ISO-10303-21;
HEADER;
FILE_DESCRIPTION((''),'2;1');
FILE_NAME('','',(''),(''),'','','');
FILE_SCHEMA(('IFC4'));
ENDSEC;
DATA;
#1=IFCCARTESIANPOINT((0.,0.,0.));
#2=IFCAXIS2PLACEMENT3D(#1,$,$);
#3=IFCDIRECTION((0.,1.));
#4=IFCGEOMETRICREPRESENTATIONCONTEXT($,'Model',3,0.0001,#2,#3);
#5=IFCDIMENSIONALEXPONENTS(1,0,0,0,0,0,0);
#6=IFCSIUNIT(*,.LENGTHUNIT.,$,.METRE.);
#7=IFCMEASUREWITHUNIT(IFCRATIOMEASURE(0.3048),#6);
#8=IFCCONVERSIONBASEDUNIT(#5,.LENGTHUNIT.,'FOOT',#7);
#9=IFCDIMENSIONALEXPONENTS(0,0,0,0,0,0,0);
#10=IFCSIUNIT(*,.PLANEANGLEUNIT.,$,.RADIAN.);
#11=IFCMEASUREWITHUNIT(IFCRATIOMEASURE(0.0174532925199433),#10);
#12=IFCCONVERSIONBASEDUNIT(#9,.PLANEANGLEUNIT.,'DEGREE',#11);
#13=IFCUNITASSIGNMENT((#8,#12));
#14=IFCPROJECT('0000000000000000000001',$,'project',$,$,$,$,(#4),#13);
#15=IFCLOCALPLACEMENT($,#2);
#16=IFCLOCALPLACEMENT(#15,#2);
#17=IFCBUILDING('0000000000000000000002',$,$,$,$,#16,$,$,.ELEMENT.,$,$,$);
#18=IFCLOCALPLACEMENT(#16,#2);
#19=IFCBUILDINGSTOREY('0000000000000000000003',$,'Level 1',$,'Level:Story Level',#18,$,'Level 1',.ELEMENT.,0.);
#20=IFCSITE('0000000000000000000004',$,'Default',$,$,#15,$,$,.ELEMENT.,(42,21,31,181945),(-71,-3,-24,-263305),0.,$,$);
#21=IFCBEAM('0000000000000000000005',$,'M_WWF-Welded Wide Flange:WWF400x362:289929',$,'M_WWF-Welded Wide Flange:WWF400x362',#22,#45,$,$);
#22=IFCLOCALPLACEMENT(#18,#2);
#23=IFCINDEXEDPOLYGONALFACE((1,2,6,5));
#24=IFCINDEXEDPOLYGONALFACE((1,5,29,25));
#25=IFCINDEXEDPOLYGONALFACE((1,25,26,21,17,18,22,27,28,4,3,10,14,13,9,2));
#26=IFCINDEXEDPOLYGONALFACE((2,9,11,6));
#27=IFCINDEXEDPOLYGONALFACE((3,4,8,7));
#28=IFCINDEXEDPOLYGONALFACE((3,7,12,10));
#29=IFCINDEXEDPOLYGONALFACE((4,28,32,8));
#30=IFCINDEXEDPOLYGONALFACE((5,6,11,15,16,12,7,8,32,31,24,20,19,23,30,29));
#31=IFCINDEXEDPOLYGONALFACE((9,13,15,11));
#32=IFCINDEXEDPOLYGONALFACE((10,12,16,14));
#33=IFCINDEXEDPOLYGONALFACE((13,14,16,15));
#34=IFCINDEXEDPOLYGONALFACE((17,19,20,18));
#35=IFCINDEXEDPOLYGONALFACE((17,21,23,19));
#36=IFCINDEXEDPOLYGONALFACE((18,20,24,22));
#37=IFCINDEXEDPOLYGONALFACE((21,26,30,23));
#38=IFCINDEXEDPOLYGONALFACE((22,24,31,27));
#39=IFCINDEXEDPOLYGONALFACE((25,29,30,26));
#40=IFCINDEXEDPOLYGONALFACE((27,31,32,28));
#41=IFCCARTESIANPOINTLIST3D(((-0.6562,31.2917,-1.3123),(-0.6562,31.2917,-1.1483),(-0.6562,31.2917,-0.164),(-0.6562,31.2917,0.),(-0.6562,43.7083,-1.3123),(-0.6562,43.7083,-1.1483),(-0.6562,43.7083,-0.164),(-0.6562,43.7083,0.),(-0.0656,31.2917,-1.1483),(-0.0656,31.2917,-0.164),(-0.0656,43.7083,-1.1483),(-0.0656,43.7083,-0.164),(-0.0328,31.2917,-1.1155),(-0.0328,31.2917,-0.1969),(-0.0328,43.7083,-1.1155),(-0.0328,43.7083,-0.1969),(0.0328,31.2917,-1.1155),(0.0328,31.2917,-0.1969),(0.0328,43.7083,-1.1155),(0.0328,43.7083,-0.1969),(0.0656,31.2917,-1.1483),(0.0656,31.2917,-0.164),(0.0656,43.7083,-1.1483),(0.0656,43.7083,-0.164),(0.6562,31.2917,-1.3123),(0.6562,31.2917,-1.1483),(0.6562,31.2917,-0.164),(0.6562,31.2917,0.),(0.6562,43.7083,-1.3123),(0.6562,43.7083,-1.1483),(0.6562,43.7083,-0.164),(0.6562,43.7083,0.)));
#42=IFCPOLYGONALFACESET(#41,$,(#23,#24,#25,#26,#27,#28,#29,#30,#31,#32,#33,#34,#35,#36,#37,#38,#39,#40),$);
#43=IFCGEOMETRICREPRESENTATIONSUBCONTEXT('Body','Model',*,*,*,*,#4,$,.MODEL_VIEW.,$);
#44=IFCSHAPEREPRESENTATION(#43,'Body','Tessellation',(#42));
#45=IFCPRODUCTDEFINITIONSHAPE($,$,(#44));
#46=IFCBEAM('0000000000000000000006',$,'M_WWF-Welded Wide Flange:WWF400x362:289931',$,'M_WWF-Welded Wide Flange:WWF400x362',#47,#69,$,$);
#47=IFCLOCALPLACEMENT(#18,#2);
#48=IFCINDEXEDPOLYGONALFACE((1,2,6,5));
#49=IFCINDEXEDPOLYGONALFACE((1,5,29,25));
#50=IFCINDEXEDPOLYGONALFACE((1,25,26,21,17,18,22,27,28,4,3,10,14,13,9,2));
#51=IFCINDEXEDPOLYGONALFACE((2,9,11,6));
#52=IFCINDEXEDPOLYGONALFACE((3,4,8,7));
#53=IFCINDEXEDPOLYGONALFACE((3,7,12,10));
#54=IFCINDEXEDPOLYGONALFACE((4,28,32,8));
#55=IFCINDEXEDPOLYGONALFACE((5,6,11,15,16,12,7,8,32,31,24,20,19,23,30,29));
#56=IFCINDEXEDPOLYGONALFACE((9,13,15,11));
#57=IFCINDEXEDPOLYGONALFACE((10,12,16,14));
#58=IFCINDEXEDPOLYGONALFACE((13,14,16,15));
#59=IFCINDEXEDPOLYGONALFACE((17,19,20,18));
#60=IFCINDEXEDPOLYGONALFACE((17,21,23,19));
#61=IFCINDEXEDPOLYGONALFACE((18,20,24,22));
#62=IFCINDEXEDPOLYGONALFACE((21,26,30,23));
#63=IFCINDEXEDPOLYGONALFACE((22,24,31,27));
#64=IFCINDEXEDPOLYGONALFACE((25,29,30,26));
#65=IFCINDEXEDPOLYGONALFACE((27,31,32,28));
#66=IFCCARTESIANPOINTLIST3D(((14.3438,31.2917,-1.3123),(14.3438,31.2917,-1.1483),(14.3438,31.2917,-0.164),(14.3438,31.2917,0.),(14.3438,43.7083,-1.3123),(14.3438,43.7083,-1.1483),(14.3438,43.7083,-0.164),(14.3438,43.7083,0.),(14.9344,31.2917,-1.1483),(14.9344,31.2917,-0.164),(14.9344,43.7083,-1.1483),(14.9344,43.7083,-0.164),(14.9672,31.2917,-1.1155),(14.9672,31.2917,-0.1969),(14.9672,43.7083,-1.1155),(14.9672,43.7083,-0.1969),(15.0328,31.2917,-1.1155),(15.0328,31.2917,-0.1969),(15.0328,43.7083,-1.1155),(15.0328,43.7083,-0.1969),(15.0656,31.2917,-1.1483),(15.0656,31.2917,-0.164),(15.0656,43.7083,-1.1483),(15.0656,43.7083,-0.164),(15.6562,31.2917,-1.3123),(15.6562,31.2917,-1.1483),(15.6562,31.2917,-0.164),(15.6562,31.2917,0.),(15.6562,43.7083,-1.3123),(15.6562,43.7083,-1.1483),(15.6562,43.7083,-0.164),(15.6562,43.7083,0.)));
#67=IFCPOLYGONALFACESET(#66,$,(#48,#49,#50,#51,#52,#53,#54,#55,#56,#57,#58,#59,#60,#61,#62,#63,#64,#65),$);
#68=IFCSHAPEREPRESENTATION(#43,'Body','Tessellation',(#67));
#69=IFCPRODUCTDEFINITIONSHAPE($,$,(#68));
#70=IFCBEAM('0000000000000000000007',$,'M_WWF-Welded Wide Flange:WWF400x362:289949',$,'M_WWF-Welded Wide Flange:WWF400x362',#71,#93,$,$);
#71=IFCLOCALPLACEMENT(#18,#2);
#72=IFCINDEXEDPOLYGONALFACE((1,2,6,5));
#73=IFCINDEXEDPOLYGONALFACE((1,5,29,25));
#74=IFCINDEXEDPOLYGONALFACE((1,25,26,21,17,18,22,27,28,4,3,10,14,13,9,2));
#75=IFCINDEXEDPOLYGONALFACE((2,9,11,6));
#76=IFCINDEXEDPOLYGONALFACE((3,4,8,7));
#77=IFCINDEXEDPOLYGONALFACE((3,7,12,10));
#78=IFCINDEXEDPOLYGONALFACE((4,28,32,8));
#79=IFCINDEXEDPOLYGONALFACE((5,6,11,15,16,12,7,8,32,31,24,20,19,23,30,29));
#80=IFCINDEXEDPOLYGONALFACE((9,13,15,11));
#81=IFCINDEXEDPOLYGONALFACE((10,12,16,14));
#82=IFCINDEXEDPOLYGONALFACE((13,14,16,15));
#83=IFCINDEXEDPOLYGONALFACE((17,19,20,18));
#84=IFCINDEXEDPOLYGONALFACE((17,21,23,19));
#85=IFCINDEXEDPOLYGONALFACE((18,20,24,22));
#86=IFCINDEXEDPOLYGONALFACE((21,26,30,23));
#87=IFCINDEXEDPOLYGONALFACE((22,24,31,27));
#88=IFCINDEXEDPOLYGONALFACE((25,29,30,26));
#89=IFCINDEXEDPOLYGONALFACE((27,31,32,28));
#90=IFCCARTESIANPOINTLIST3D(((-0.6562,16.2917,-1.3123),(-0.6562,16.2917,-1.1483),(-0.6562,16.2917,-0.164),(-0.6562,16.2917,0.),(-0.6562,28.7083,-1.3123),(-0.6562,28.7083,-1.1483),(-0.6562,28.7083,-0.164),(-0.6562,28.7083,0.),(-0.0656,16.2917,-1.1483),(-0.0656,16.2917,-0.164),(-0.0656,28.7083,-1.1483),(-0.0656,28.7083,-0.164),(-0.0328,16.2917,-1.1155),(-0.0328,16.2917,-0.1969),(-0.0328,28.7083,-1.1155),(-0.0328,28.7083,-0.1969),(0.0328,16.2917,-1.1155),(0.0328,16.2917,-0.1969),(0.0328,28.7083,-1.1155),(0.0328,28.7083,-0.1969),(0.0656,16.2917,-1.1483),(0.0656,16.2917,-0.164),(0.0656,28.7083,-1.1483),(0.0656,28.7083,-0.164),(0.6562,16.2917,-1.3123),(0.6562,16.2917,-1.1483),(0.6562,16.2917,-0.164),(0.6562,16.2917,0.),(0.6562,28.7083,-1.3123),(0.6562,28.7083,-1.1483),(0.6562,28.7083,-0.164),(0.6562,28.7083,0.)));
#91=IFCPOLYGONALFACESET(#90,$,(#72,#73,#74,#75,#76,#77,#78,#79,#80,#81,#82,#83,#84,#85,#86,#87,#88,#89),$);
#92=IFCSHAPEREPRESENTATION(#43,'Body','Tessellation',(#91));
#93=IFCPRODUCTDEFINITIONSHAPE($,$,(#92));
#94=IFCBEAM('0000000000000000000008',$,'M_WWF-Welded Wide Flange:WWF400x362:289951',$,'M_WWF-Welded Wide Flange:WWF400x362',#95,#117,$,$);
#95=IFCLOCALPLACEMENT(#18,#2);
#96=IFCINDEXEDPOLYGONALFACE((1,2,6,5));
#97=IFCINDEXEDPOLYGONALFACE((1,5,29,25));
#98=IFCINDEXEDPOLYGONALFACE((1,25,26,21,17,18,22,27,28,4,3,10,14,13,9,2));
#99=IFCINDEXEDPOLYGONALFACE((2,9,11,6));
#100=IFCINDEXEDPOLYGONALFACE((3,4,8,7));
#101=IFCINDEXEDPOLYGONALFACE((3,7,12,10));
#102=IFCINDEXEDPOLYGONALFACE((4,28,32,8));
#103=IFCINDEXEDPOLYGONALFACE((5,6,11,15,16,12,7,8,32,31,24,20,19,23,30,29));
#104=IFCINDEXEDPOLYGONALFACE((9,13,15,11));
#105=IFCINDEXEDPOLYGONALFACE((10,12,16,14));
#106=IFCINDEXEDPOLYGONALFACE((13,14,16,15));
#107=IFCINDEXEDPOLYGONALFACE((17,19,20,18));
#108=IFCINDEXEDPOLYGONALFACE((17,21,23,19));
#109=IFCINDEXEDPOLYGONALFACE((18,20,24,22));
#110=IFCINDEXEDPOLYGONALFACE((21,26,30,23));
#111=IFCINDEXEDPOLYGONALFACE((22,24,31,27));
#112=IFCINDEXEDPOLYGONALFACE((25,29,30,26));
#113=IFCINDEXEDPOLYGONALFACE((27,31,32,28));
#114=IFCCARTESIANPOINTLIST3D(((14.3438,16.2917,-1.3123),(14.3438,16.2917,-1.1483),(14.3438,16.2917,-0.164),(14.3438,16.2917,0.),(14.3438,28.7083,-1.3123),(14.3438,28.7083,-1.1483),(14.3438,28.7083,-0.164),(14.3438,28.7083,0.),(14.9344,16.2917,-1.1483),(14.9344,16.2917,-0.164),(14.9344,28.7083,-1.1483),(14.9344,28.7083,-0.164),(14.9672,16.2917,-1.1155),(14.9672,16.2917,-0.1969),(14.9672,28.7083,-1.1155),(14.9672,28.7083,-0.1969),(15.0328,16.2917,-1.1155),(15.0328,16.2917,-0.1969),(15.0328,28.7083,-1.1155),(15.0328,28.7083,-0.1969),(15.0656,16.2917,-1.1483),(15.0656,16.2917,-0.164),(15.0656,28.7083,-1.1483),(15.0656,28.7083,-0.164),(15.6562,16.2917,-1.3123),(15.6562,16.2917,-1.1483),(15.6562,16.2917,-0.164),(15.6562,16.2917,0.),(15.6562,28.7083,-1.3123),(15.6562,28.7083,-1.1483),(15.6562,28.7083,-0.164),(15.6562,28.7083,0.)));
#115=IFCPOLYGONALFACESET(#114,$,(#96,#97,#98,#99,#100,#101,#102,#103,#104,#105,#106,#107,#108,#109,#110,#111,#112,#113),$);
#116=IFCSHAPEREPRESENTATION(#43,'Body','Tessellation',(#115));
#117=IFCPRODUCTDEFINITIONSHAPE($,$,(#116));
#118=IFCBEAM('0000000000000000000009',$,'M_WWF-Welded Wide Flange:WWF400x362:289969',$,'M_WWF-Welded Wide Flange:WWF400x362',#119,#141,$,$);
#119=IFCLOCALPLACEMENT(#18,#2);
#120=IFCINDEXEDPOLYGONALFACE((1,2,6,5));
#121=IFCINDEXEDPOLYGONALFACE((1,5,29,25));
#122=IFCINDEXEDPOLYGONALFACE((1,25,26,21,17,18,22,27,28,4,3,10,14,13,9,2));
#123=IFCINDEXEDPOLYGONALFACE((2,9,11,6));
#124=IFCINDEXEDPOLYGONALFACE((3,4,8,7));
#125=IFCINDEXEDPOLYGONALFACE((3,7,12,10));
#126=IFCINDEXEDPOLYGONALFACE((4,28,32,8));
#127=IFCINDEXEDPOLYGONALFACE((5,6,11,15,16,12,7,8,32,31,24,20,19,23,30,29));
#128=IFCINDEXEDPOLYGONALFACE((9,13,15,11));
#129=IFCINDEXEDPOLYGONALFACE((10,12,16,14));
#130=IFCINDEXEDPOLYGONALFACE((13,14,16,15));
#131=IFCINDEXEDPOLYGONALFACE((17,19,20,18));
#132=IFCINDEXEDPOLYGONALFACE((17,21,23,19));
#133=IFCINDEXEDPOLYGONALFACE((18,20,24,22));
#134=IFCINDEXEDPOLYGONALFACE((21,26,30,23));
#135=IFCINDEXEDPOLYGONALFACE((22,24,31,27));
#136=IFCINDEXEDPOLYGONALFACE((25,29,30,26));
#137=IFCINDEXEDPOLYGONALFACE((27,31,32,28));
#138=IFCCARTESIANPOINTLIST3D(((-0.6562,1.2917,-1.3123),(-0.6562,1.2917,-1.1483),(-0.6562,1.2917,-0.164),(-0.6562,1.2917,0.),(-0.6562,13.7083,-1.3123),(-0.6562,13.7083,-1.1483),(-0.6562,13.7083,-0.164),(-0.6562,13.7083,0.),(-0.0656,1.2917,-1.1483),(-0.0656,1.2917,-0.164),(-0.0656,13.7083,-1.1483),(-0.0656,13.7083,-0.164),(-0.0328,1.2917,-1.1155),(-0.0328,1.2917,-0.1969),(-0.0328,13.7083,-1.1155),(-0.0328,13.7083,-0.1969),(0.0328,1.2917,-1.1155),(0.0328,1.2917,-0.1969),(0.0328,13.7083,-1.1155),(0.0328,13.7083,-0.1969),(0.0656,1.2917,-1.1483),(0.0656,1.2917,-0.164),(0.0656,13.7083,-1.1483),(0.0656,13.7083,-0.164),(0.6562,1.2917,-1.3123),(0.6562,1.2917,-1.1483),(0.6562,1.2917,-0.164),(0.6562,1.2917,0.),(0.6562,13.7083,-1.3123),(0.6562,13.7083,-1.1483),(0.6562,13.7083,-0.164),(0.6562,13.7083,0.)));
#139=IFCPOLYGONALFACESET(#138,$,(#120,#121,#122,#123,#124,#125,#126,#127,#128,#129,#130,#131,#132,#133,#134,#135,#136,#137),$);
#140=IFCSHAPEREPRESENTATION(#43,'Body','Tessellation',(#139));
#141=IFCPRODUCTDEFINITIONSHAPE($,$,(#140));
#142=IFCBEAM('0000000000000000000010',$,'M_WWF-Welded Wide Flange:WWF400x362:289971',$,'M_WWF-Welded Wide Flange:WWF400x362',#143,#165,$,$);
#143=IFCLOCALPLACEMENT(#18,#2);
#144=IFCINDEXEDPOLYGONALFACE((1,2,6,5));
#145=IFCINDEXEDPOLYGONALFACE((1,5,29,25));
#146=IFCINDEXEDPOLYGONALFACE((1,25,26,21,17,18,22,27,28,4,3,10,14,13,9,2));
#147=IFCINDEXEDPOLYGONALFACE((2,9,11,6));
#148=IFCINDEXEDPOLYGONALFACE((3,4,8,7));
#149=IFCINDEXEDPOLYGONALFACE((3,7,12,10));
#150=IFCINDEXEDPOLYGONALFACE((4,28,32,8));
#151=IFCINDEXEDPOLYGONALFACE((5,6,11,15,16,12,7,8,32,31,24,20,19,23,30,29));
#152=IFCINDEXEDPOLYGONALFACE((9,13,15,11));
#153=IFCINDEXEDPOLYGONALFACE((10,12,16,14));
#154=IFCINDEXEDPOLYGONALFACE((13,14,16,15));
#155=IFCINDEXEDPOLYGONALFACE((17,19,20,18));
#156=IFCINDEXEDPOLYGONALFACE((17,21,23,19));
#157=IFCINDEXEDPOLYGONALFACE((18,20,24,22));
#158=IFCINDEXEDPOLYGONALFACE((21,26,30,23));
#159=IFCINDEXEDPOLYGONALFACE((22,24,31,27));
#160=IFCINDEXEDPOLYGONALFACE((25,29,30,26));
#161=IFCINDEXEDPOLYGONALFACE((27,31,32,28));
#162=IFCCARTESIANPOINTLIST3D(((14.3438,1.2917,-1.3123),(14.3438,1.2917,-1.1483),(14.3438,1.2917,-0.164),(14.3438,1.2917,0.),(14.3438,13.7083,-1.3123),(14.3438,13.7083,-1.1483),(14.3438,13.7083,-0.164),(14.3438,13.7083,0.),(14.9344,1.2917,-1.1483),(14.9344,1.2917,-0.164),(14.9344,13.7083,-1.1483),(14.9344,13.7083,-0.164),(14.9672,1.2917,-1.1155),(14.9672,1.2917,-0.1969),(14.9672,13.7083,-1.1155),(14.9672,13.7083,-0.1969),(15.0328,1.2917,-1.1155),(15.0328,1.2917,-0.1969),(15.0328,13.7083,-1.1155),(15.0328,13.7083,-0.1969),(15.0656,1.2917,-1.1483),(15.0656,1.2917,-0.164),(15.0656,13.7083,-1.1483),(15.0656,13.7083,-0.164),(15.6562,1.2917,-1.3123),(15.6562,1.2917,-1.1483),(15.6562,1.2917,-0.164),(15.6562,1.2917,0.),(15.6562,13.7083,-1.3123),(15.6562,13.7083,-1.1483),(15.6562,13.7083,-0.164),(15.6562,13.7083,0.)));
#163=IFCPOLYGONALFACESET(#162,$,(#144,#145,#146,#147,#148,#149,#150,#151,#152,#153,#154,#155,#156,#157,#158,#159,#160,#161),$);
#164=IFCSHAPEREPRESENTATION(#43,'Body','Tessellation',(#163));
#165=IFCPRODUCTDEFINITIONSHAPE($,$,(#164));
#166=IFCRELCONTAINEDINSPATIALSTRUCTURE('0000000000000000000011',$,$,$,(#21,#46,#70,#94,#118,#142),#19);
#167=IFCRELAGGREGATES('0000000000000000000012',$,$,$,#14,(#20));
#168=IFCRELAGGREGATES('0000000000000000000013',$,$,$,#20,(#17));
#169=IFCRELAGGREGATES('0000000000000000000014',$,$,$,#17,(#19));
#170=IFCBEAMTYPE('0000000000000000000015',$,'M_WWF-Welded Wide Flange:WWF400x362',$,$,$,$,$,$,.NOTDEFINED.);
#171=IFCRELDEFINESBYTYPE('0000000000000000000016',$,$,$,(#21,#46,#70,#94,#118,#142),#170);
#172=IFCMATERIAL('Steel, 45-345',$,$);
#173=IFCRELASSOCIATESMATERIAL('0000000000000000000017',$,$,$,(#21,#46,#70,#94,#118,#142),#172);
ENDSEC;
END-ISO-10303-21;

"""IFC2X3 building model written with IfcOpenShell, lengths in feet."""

from ifc_helpers import new_model, entity, si_unit, converted_unit, direction, frame, origin, place, context, subcontext, project, spatial, polyline, outline, extrude, material, type_object, element, save


model = new_model("IFC2X3")

# Units and contexts
model_context = context("Model", 3, precision=0.0001, world=origin(), true_north=direction((0.0, 1.0)))
body_context = subcontext(model_context, "Body", "Model", "MODEL_VIEW")
ifc_project = project(units=[converted_unit("LENGTHUNIT", "FOOT", entity("IfcRatioMeasure", 0.3048), si_unit("LENGTHUNIT", "METRE"), dimensions=[1, 0, 0, 0, 0, 0, 0]), converted_unit("PLANEANGLEUNIT", "DEGREE", entity("IfcRatioMeasure", 0.0174532925199433), si_unit("PLANEANGLEUNIT", "RADIAN"), dimensions=[0, 0, 0, 0, 0, 0, 0])], contexts=[model_context])

# Site, building, storey
site_placement = place(None, origin())
site = spatial("IfcSite", under=ifc_project, at=site_placement, Name="Default", CompositionType="ELEMENT", RefLatitude=(42, 21, 31, 181945), RefLongitude=(-71, -3, -24, -263305), RefElevation=0.0)
building_placement = place(site_placement, origin())
building = spatial("IfcBuilding", under=site, at=building_placement, CompositionType="ELEMENT")
storey_placement = place(building_placement, origin())
storey = spatial("IfcBuildingStorey", under=building, at=storey_placement, Name="Level 1", ObjectType="Level:Story Level", LongName="Level 1", CompositionType="ELEMENT", Elevation=0.0)

# Shared definitions
ifc_material = material(Name="Steel, 45-345")

# Beams
beam_type = type_object("IfcBeamType", Name="M_WWF-Welded Wide Flange:WWF400x362", PredefinedType="NOTDEFINED")
beam_1_placement = place(storey_placement, frame((0.0, 30.0, 0.0), z_axis=(0.0, 0.0, 1.0), x_axis=(0.0, 1.0, 0.0)))
element("IfcBeam", 1, at=beam_1_placement, inside=storey, type_object=beam_type, material=ifc_material, Name="M_WWF-Welded Wide Flange:WWF400x362:289929", ObjectType="M_WWF-Welded Wide Flange:WWF400x362", context=body_context, shape_type="SweptSolid", body=[
    extrude(outline(polyline([(-0.6562, -0.6562), (-0.4921, -0.6562), (-0.4921, -0.0656), (-0.4593, -0.0328), (0.4593, -0.0328), (0.4921, -0.0656), (0.4921, -0.6562), (0.6562, -0.6562), (0.6562, 0.6562), (0.4921, 0.6562), (0.4921, 0.0656), (0.4593, 0.0328), (-0.4593, 0.0328), (-0.4921, 0.0656), (-0.4921, 0.6562), (-0.6562, 0.6562), (-0.6562, -0.6562)])), frame((1.2917, 0.0, -0.6562), z_axis=(1.0, 0.0, 0.0), x_axis=(0.0, 0.0, -1.0)), (0.0, 0.0, 1.0), 12.4167),
])
beam_2_placement = place(storey_placement, frame((15.0, 30.0, 0.0), z_axis=(0.0, 0.0, 1.0), x_axis=(0.0, 1.0, 0.0)))
element("IfcBeam", 2, at=beam_2_placement, inside=storey, type_object=beam_type, material=ifc_material, Name="M_WWF-Welded Wide Flange:WWF400x362:289931", ObjectType="M_WWF-Welded Wide Flange:WWF400x362", context=body_context, shape_type="SweptSolid", body=[
    extrude(outline(polyline([(-0.6562, -0.6562), (-0.4921, -0.6562), (-0.4921, -0.0656), (-0.4593, -0.0328), (0.4593, -0.0328), (0.4921, -0.0656), (0.4921, -0.6562), (0.6562, -0.6562), (0.6562, 0.6562), (0.4921, 0.6562), (0.4921, 0.0656), (0.4593, 0.0328), (-0.4593, 0.0328), (-0.4921, 0.0656), (-0.4921, 0.6562), (-0.6562, 0.6562), (-0.6562, -0.6562)])), frame((1.2917, 0.0, -0.6562), z_axis=(1.0, 0.0, 0.0), x_axis=(0.0, 0.0, -1.0)), (0.0, 0.0, 1.0), 12.4167),
])
beam_3_placement = place(storey_placement, frame((0.0, 15.0, 0.0), z_axis=(0.0, 0.0, 1.0), x_axis=(0.0, 1.0, 0.0)))
element("IfcBeam", 3, at=beam_3_placement, inside=storey, type_object=beam_type, material=ifc_material, Name="M_WWF-Welded Wide Flange:WWF400x362:289949", ObjectType="M_WWF-Welded Wide Flange:WWF400x362", context=body_context, shape_type="SweptSolid", body=[
    extrude(outline(polyline([(-0.6562, -0.6562), (-0.4921, -0.6562), (-0.4921, -0.0656), (-0.4593, -0.0328), (0.4593, -0.0328), (0.4921, -0.0656), (0.4921, -0.6562), (0.6562, -0.6562), (0.6562, 0.6562), (0.4921, 0.6562), (0.4921, 0.0656), (0.4593, 0.0328), (-0.4593, 0.0328), (-0.4921, 0.0656), (-0.4921, 0.6562), (-0.6562, 0.6562), (-0.6562, -0.6562)])), frame((1.2917, 0.0, -0.6562), z_axis=(1.0, 0.0, 0.0), x_axis=(0.0, 0.0, -1.0)), (0.0, 0.0, 1.0), 12.4167),
])
beam_4_placement = place(storey_placement, frame((15.0, 15.0, 0.0), z_axis=(0.0, 0.0, 1.0), x_axis=(0.0, 1.0, 0.0)))
element("IfcBeam", 4, at=beam_4_placement, inside=storey, type_object=beam_type, material=ifc_material, Name="M_WWF-Welded Wide Flange:WWF400x362:289951", ObjectType="M_WWF-Welded Wide Flange:WWF400x362", context=body_context, shape_type="SweptSolid", body=[
    extrude(outline(polyline([(-0.6562, -0.6562), (-0.4921, -0.6562), (-0.4921, -0.0656), (-0.4593, -0.0328), (0.4593, -0.0328), (0.4921, -0.0656), (0.4921, -0.6562), (0.6562, -0.6562), (0.6562, 0.6562), (0.4921, 0.6562), (0.4921, 0.0656), (0.4593, 0.0328), (-0.4593, 0.0328), (-0.4921, 0.0656), (-0.4921, 0.6562), (-0.6562, 0.6562), (-0.6562, -0.6562)])), frame((1.2917, 0.0, -0.6562), z_axis=(1.0, 0.0, 0.0), x_axis=(0.0, 0.0, -1.0)), (0.0, 0.0, 1.0), 12.4167),
])
beam_5_placement = place(storey_placement, frame((0.0, 0.0, 0.0), z_axis=(0.0, 0.0, 1.0), x_axis=(0.0, 1.0, 0.0)))
element("IfcBeam", 5, at=beam_5_placement, inside=storey, type_object=beam_type, material=ifc_material, Name="M_WWF-Welded Wide Flange:WWF400x362:289969", ObjectType="M_WWF-Welded Wide Flange:WWF400x362", context=body_context, shape_type="SweptSolid", body=[
    extrude(outline(polyline([(-0.6562, -0.6562), (-0.4921, -0.6562), (-0.4921, -0.0656), (-0.4593, -0.0328), (0.4593, -0.0328), (0.4921, -0.0656), (0.4921, -0.6562), (0.6562, -0.6562), (0.6562, 0.6562), (0.4921, 0.6562), (0.4921, 0.0656), (0.4593, 0.0328), (-0.4593, 0.0328), (-0.4921, 0.0656), (-0.4921, 0.6562), (-0.6562, 0.6562), (-0.6562, -0.6562)])), frame((1.2917, 0.0, -0.6562), z_axis=(1.0, 0.0, 0.0), x_axis=(0.0, 0.0, -1.0)), (0.0, 0.0, 1.0), 12.4167),
])
beam_6_placement = place(storey_placement, frame((15.0, 0.0, 0.0), z_axis=(0.0, 0.0, 1.0), x_axis=(0.0, 1.0, 0.0)))
element("IfcBeam", 6, at=beam_6_placement, inside=storey, type_object=beam_type, material=ifc_material, Name="M_WWF-Welded Wide Flange:WWF400x362:289971", ObjectType="M_WWF-Welded Wide Flange:WWF400x362", context=body_context, shape_type="SweptSolid", body=[
    extrude(outline(polyline([(-0.6562, -0.6562), (-0.4921, -0.6562), (-0.4921, -0.0656), (-0.4593, -0.0328), (0.4593, -0.0328), (0.4921, -0.0656), (0.4921, -0.6562), (0.6562, -0.6562), (0.6562, 0.6562), (0.4921, 0.6562), (0.4921, 0.0656), (0.4593, 0.0328), (-0.4593, 0.0328), (-0.4921, 0.0656), (-0.4921, 0.6562), (-0.6562, 0.6562), (-0.6562, -0.6562)])), frame((1.2917, 0.0, -0.6562), z_axis=(1.0, 0.0, 0.0), x_axis=(0.0, 0.0, -1.0)), (0.0, 0.0, 1.0), 12.4167),
])

save(model, "model.ifc")
